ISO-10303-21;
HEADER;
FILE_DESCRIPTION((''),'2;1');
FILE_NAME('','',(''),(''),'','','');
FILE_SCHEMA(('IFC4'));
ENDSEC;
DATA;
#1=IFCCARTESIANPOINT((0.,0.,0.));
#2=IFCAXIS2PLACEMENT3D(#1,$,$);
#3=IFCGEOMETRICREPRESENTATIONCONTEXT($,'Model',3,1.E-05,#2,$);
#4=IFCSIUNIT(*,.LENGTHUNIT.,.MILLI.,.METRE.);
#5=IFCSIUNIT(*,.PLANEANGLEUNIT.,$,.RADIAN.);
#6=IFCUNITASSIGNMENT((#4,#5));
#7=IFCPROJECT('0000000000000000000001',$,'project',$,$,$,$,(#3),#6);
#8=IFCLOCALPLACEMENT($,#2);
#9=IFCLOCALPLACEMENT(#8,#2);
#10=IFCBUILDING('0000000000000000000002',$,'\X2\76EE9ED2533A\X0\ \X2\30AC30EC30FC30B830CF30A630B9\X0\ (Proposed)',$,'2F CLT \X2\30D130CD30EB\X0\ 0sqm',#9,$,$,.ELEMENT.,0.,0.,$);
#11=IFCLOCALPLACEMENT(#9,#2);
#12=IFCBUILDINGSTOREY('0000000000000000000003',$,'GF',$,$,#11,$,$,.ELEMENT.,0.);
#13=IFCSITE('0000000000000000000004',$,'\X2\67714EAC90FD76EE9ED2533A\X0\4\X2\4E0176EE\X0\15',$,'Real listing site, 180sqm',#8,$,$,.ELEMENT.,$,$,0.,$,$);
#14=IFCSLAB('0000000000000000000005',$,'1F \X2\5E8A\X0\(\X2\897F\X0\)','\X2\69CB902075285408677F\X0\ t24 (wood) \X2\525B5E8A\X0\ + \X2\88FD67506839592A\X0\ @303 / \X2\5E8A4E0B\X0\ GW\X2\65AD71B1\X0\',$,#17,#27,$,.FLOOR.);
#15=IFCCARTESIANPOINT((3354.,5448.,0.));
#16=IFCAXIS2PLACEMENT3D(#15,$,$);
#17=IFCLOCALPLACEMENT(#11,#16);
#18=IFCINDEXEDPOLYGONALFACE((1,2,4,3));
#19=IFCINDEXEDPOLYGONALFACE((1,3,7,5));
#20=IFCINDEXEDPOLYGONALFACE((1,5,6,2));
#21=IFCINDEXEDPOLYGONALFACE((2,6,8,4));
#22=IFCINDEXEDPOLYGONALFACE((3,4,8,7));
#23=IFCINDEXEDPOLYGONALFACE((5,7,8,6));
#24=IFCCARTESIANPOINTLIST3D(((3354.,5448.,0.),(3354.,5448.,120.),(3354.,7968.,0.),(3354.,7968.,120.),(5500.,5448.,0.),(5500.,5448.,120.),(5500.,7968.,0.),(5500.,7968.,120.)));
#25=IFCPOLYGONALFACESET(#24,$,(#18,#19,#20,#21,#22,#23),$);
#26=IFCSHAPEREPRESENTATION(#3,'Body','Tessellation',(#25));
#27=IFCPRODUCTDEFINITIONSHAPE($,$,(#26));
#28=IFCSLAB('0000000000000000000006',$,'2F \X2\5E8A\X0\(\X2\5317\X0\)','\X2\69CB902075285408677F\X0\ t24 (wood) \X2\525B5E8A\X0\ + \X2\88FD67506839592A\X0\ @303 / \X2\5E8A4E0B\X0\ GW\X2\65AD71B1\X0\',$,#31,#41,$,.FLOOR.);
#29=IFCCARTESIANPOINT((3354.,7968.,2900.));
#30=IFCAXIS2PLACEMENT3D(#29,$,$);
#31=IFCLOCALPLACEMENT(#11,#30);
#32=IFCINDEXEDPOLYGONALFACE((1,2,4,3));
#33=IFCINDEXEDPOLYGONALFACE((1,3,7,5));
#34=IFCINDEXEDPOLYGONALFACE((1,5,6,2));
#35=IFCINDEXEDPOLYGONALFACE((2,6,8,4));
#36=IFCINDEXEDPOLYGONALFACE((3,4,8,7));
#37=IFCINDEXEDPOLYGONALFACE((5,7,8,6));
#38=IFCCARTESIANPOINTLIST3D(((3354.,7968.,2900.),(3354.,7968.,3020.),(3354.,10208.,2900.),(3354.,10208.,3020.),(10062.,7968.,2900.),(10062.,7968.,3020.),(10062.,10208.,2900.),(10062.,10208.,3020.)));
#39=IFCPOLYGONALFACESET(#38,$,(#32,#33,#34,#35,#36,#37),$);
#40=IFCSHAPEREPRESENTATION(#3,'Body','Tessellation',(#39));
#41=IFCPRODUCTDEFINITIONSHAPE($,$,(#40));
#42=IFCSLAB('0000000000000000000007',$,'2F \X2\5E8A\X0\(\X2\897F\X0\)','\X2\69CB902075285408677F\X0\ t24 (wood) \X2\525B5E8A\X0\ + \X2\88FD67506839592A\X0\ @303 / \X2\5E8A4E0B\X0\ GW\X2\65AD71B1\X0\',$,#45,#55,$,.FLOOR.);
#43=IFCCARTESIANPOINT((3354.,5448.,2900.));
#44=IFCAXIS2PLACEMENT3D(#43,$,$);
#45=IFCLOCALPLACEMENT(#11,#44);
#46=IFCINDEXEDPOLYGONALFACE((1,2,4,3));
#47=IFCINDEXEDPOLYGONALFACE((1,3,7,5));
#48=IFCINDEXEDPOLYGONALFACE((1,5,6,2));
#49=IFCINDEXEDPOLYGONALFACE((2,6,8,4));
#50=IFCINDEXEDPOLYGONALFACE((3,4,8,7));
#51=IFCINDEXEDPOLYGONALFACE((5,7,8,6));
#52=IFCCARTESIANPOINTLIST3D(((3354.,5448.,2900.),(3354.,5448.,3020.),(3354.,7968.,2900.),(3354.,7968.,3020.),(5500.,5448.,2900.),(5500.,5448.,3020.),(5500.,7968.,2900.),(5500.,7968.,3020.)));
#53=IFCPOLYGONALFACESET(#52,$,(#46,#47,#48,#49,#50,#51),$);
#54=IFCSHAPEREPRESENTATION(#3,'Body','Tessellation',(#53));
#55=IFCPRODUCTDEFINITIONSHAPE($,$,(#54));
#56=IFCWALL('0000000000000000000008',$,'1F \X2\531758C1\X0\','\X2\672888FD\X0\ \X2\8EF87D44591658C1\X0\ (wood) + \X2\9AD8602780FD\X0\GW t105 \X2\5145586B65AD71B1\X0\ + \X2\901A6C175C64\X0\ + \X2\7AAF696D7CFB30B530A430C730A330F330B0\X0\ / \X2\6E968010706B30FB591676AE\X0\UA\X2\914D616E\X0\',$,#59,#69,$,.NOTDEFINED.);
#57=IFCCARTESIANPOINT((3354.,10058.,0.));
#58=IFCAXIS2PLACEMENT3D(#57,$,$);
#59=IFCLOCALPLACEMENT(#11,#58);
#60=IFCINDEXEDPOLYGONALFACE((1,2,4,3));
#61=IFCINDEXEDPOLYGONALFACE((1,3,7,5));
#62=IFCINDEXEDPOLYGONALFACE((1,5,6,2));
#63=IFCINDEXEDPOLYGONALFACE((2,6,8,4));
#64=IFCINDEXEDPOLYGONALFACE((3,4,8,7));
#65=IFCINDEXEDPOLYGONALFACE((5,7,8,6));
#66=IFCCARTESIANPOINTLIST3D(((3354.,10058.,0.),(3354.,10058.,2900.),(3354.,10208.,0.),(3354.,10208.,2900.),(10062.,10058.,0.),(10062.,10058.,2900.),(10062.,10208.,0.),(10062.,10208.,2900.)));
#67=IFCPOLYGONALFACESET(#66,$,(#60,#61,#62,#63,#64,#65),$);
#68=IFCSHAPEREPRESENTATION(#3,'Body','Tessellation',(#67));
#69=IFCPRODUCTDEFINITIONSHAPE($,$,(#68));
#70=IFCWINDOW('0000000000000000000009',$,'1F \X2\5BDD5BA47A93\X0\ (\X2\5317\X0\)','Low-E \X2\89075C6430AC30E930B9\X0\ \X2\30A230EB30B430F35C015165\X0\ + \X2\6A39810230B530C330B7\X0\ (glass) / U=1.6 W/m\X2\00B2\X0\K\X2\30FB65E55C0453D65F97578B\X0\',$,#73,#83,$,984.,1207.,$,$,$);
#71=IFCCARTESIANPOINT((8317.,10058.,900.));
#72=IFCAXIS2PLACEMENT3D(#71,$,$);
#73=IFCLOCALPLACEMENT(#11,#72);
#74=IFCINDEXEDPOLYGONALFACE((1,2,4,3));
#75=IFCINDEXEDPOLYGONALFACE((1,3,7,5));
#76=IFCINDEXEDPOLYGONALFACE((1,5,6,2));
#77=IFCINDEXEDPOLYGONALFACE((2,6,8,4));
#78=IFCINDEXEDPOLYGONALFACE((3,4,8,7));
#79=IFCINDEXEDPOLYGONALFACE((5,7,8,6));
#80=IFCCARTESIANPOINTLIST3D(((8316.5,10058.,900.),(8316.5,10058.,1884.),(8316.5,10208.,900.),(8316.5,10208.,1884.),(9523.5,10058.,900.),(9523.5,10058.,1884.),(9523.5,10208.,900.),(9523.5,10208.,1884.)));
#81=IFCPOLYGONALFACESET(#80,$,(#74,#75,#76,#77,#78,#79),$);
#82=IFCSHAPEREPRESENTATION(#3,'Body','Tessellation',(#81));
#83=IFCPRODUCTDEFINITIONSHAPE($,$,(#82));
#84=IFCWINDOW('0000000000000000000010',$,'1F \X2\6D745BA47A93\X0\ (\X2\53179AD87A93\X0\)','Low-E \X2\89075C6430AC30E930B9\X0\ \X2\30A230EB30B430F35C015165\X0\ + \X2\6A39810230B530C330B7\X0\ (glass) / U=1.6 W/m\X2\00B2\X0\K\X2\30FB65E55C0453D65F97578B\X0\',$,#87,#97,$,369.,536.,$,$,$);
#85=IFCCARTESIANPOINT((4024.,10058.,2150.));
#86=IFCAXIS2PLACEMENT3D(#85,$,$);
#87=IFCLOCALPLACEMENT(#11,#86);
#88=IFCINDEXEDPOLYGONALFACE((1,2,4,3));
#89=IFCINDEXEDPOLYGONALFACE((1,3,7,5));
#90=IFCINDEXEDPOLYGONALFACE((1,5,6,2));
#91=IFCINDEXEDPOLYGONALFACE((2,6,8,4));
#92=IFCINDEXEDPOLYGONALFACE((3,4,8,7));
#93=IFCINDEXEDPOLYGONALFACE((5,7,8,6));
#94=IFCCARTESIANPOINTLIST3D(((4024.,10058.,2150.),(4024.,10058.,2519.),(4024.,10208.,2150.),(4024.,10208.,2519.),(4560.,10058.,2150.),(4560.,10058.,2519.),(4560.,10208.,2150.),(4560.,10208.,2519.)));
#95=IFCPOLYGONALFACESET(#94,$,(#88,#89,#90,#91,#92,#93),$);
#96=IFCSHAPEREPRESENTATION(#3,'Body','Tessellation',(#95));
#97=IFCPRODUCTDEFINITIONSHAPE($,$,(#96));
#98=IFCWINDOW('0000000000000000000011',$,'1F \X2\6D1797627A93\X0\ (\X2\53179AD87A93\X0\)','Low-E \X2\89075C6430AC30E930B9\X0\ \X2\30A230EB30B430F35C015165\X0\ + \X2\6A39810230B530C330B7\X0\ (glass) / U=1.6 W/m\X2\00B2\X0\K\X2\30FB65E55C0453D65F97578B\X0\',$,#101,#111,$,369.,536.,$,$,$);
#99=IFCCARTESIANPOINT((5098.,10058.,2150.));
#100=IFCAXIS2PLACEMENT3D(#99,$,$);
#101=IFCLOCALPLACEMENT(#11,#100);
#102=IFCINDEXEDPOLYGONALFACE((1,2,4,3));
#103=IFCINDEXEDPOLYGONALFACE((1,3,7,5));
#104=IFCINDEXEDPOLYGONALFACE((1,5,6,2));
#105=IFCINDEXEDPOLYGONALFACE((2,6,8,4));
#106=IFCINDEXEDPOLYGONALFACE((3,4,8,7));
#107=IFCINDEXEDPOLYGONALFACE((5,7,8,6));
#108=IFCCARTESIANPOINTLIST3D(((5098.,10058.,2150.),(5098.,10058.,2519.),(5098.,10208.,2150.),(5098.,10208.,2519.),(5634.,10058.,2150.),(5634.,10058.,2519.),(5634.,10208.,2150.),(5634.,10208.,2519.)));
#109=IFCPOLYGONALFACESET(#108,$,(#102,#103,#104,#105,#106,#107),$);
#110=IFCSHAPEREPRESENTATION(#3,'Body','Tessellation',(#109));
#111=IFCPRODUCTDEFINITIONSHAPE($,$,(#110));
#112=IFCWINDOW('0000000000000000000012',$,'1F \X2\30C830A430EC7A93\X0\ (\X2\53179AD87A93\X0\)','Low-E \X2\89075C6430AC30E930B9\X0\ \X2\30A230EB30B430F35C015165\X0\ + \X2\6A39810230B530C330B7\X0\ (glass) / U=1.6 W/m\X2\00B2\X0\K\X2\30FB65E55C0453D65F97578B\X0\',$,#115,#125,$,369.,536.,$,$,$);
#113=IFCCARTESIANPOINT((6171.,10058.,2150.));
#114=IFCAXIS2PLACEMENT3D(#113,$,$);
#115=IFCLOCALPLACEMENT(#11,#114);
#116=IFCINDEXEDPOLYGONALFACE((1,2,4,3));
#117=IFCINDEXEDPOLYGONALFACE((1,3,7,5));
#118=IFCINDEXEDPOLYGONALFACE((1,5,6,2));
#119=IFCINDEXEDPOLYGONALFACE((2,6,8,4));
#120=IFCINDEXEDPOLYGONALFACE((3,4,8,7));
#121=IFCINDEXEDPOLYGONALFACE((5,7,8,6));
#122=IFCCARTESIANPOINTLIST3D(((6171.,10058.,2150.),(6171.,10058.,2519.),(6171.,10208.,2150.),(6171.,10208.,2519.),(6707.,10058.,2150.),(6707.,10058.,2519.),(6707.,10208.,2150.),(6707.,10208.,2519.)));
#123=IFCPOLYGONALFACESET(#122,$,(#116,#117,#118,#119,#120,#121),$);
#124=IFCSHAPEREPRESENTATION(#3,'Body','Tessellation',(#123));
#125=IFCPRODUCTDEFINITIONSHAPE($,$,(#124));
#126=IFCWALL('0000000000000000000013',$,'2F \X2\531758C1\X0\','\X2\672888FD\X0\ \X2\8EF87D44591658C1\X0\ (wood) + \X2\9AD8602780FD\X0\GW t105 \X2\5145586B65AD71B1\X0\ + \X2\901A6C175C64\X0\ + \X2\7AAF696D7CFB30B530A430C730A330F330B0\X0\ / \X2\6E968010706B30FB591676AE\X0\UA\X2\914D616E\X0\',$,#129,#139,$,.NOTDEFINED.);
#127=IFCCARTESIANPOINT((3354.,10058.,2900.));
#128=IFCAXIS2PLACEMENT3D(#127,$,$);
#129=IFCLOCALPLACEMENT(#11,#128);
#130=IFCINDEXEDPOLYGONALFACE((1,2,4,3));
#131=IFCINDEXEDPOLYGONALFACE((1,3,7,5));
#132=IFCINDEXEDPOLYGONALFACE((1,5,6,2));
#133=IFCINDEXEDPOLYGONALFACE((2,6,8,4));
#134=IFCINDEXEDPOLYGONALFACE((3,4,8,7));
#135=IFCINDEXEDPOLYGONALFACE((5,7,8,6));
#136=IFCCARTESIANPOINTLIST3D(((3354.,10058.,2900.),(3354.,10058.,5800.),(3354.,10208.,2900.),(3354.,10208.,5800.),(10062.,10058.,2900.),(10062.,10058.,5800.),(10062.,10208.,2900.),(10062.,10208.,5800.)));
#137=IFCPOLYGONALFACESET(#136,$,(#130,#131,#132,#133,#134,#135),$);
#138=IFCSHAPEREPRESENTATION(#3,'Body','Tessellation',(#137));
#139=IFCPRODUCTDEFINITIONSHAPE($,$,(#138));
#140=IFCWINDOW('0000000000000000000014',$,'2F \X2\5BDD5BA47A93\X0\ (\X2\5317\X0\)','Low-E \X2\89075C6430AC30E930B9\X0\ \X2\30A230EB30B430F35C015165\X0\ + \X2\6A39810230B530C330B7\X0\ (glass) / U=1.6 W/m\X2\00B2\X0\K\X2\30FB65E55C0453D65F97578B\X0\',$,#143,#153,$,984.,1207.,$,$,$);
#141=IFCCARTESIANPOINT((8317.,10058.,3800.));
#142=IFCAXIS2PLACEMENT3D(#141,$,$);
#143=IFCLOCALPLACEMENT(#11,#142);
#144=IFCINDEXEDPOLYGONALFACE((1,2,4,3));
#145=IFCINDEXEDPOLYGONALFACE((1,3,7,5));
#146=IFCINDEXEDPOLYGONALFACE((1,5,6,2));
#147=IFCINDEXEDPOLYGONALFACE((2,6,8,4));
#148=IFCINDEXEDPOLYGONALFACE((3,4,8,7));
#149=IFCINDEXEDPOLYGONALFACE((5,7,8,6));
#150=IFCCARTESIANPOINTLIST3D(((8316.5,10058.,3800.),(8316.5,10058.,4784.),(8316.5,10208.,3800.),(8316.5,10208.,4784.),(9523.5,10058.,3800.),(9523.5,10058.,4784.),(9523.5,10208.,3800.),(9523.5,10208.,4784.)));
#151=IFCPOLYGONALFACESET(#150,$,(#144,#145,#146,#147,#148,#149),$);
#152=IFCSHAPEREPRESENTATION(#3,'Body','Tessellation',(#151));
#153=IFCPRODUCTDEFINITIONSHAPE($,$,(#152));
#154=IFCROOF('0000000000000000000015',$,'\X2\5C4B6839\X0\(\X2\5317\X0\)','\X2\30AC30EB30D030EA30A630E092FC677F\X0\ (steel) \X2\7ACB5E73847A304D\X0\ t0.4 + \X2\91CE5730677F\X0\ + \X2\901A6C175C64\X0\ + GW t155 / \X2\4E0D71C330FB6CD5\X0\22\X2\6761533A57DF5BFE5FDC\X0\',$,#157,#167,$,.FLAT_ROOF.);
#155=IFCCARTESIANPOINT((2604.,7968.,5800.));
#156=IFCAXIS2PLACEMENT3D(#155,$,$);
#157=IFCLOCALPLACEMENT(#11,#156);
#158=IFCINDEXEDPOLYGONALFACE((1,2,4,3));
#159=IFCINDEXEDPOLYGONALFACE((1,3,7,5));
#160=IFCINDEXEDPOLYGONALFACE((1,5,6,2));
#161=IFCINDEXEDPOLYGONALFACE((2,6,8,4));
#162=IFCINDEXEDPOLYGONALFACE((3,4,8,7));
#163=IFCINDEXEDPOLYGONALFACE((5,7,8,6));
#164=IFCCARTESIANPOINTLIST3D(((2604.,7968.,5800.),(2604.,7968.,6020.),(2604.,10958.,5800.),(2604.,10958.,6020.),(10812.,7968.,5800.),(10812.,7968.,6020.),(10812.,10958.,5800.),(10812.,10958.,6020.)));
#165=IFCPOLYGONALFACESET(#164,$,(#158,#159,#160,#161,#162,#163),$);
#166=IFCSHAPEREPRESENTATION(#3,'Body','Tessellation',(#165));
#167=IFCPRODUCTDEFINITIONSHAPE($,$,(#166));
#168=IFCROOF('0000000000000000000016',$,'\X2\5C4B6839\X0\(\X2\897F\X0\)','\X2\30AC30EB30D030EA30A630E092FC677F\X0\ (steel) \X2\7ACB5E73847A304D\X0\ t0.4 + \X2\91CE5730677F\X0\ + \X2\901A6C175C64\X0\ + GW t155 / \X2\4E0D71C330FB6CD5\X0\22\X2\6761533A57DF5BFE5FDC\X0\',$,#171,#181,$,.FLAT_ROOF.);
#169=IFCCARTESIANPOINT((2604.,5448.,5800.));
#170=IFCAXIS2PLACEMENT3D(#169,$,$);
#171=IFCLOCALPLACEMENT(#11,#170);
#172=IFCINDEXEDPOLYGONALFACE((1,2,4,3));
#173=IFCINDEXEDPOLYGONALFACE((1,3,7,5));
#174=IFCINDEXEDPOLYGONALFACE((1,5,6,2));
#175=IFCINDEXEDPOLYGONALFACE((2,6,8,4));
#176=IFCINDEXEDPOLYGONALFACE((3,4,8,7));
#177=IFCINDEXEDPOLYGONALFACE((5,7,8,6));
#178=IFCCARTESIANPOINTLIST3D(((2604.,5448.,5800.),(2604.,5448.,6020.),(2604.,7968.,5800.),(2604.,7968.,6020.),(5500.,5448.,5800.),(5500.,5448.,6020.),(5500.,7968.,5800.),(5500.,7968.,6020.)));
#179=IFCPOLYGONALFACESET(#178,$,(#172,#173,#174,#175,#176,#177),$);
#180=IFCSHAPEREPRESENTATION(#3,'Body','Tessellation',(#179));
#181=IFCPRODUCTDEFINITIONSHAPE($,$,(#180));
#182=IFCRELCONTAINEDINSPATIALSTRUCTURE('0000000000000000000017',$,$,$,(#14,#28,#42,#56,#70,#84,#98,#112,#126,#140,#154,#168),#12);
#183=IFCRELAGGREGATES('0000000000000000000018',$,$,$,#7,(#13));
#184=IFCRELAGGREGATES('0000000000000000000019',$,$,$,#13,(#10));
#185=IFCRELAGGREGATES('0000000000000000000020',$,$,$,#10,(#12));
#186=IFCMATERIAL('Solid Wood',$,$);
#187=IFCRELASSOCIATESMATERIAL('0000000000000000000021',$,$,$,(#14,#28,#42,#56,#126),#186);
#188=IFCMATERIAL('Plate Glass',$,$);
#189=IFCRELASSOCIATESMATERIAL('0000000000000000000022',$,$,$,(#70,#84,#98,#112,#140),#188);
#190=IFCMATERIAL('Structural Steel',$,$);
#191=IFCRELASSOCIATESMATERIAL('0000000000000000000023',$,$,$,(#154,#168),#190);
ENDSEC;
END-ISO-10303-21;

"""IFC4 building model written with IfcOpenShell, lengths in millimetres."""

from ifc_helpers import new_model, si_unit, frame, frame_2d, origin, place, context, project, spatial, rectangle, extrude, material, element, fill, save


model = new_model("IFC4")

# Units and contexts
model_context = context("Model", 3, precision=1e-05, world=origin())
ifc_project = project(units=[si_unit("LENGTHUNIT", "METRE", prefix="MILLI"), si_unit("PLANEANGLEUNIT", "RADIAN")], contexts=[model_context])

# Site, building, storey
site_placement = place(None, origin())
site = spatial("IfcSite", under=ifc_project, at=site_placement, Name="東京都目黒区4丁目15", ObjectType="Real listing site, 180sqm", CompositionType="ELEMENT", RefElevation=0.0)
building_placement = place(site_placement, origin())
building = spatial("IfcBuilding", under=site, at=building_placement, Name="目黒区 ガレージハウス (Proposed)", ObjectType="2F CLT パネル 0sqm", CompositionType="ELEMENT", ElevationOfRefHeight=0.0, ElevationOfTerrain=0.0)
storey_placement = place(building_placement, origin())
storey = spatial("IfcBuildingStorey", under=building, at=storey_placement, Name="GF", CompositionType="ELEMENT", Elevation=0.0)

# Slabs
ifc_material_1 = material(Name="Solid Wood")
slab_1_placement = place(storey_placement, frame((3354.0, 5448.0, 0.0)))
element("IfcSlab", 1, at=slab_1_placement, inside=storey, material=ifc_material_1, Name="1F 床(西)", Description="構造用合板 t24 (wood) 剛床 + 製材根太 @303 / 床下 GW断熱", PredefinedType="FLOOR", context=model_context, shape_type="SweptSolid", body=[
    extrude(rectangle(XDim=2146.0, YDim=2520.0, at=frame_2d((1073.0, 1260.0))), frame((3354.0, 5448.0, 0.0)), (0.0, 0.0, 1.0), 120.0),
])
slab_2_placement = place(storey_placement, frame((3354.0, 7968.0, 2900.0)))
element("IfcSlab", 2, at=slab_2_placement, inside=storey, material=ifc_material_1, Name="2F 床(北)", Description="構造用合板 t24 (wood) 剛床 + 製材根太 @303 / 床下 GW断熱", PredefinedType="FLOOR", context=model_context, shape_type="SweptSolid", body=[
    extrude(rectangle(XDim=6708.0, YDim=2240.0, at=frame_2d((3354.0, 1120.0))), frame((3354.0, 7968.0, 2900.0)), (0.0, 0.0, 1.0), 120.0),
])
slab_3_placement = place(storey_placement, frame((3354.0, 5448.0, 2900.0)))
element("IfcSlab", 3, at=slab_3_placement, inside=storey, material=ifc_material_1, Name="2F 床(西)", Description="構造用合板 t24 (wood) 剛床 + 製材根太 @303 / 床下 GW断熱", PredefinedType="FLOOR", context=model_context, shape_type="SweptSolid", body=[
    extrude(rectangle(XDim=2146.0, YDim=2520.0, at=frame_2d((1073.0, 1260.0))), frame((3354.0, 5448.0, 2900.0)), (0.0, 0.0, 1.0), 120.0),
])

# Wall, openings, windows
wall_1_placement = place(storey_placement, frame((3354.0, 10058.0, 0.0)))
wall_1 = element("IfcWall", 4, at=wall_1_placement, inside=storey, material=ifc_material_1, Name="1F 北壁", Description="木製 軸組外壁 (wood) + 高性能GW t105 充填断熱 + 通気層 + 窯業系サイディング / 準耐火・外皮UA配慮", PredefinedType="NOTDEFINED", context=model_context, shape_type="SweptSolid", body=[
    extrude(rectangle(XDim=6708.0, YDim=150.0, at=frame_2d((3354.0, 75.0))), frame((3354.0, 10058.0, 0.0)), (0.0, 0.0, 1.0), 2900.0),
])
opening_1_placement = place(storey_placement, frame((8317.0, 10058.0, 900.0)))
opening_1 = element("IfcOpeningElement", 5, at=opening_1_placement, cuts=wall_1, PredefinedType="NOTDEFINED", context=model_context, shape_type="SweptSolid", body=[
    extrude(rectangle(XDim=1207.0, YDim=150.0, at=frame_2d((603.0, 75.0))), frame((8317.0, 10058.0, 900.0)), (0.0, 0.0, 1.0), 984.0),
])
opening_2_placement = place(storey_placement, frame((4024.0, 10058.0, 2150.0)))
opening_2 = element("IfcOpeningElement", 6, at=opening_2_placement, cuts=wall_1, PredefinedType="NOTDEFINED", context=model_context, shape_type="SweptSolid", body=[
    extrude(rectangle(XDim=536.0, YDim=150.0, at=frame_2d((268.0, 75.0))), frame((4024.0, 10058.0, 2150.0)), (0.0, 0.0, 1.0), 369.0),
])
opening_3_placement = place(storey_placement, frame((5098.0, 10058.0, 2150.0)))
opening_3 = element("IfcOpeningElement", 7, at=opening_3_placement, cuts=wall_1, PredefinedType="NOTDEFINED", context=model_context, shape_type="SweptSolid", body=[
    extrude(rectangle(XDim=536.0, YDim=150.0, at=frame_2d((268.0, 75.0))), frame((5098.0, 10058.0, 2150.0)), (0.0, 0.0, 1.0), 369.0),
])
opening_4_placement = place(storey_placement, frame((6171.0, 10058.0, 2150.0)))
opening_4 = element("IfcOpeningElement", 8, at=opening_4_placement, cuts=wall_1, PredefinedType="NOTDEFINED", context=model_context, shape_type="SweptSolid", body=[
    extrude(rectangle(XDim=536.0, YDim=150.0, at=frame_2d((268.0, 75.0))), frame((6171.0, 10058.0, 2150.0)), (0.0, 0.0, 1.0), 369.0),
])
ifc_material_2 = material(Name="Plate Glass")
window_1_placement = place(storey_placement, frame((8317.0, 10058.0, 900.0)))
window_1 = element("IfcWindow", 9, at=window_1_placement, inside=storey, material=ifc_material_2, Name="1F 寝室窓 (北)", Description="Low-E 複層ガラス アルゴン封入 + 樹脂サッシ (glass) / U=1.6 W/m²K・日射取得型", OverallHeight=984.0, OverallWidth=1207.0, context=model_context, shape_type="SweptSolid", body=[
    extrude(rectangle(XDim=1207.0, YDim=150.0, at=frame_2d((603.0, 75.0))), frame((8317.0, 10058.0, 900.0)), (0.0, 0.0, 1.0), 984.0),
])
fill(opening_1, window_1)
window_2_placement = place(storey_placement, frame((4024.0, 10058.0, 2150.0)))
window_2 = element("IfcWindow", 10, at=window_2_placement, inside=storey, material=ifc_material_2, Name="1F 浴室窓 (北高窓)", Description="Low-E 複層ガラス アルゴン封入 + 樹脂サッシ (glass) / U=1.6 W/m²K・日射取得型", OverallHeight=369.0, OverallWidth=536.0, context=model_context, shape_type="SweptSolid", body=[
    extrude(rectangle(XDim=536.0, YDim=150.0, at=frame_2d((268.0, 75.0))), frame((4024.0, 10058.0, 2150.0)), (0.0, 0.0, 1.0), 369.0),
])
fill(opening_2, window_2)
window_3_placement = place(storey_placement, frame((5098.0, 10058.0, 2150.0)))
window_3 = element("IfcWindow", 11, at=window_3_placement, inside=storey, material=ifc_material_2, Name="1F 洗面窓 (北高窓)", Description="Low-E 複層ガラス アルゴン封入 + 樹脂サッシ (glass) / U=1.6 W/m²K・日射取得型", OverallHeight=369.0, OverallWidth=536.0, context=model_context, shape_type="SweptSolid", body=[
    extrude(rectangle(XDim=536.0, YDim=150.0, at=frame_2d((268.0, 75.0))), frame((5098.0, 10058.0, 2150.0)), (0.0, 0.0, 1.0), 369.0),
])
fill(opening_3, window_3)
window_4_placement = place(storey_placement, frame((6171.0, 10058.0, 2150.0)))
window_4 = element("IfcWindow", 12, at=window_4_placement, inside=storey, material=ifc_material_2, Name="1F トイレ窓 (北高窓)", Description="Low-E 複層ガラス アルゴン封入 + 樹脂サッシ (glass) / U=1.6 W/m²K・日射取得型", OverallHeight=369.0, OverallWidth=536.0, context=model_context, shape_type="SweptSolid", body=[
    extrude(rectangle(XDim=536.0, YDim=150.0, at=frame_2d((268.0, 75.0))), frame((6171.0, 10058.0, 2150.0)), (0.0, 0.0, 1.0), 369.0),
])
fill(opening_4, window_4)

# Wall, opening, window
wall_2_placement = place(storey_placement, frame((3354.0, 10058.0, 2900.0)))
wall_2 = element("IfcWall", 13, at=wall_2_placement, inside=storey, material=ifc_material_1, Name="2F 北壁", Description="木製 軸組外壁 (wood) + 高性能GW t105 充填断熱 + 通気層 + 窯業系サイディング / 準耐火・外皮UA配慮", PredefinedType="NOTDEFINED", context=model_context, shape_type="SweptSolid", body=[
    extrude(rectangle(XDim=6708.0, YDim=150.0, at=frame_2d((3354.0, 75.0))), frame((3354.0, 10058.0, 2900.0)), (0.0, 0.0, 1.0), 2900.0),
])
opening_5_placement = place(storey_placement, frame((8317.0, 10058.0, 3800.0)))
opening_5 = element("IfcOpeningElement", 14, at=opening_5_placement, cuts=wall_2, PredefinedType="NOTDEFINED", context=model_context, shape_type="SweptSolid", body=[
    extrude(rectangle(XDim=1207.0, YDim=150.0, at=frame_2d((603.0, 75.0))), frame((8317.0, 10058.0, 3800.0)), (0.0, 0.0, 1.0), 984.0),
])
window_5_placement = place(storey_placement, frame((8317.0, 10058.0, 3800.0)))
window_5 = element("IfcWindow", 15, at=window_5_placement, inside=storey, material=ifc_material_2, Name="2F 寝室窓 (北)", Description="Low-E 複層ガラス アルゴン封入 + 樹脂サッシ (glass) / U=1.6 W/m²K・日射取得型", OverallHeight=984.0, OverallWidth=1207.0, context=model_context, shape_type="SweptSolid", body=[
    extrude(rectangle(XDim=1207.0, YDim=150.0, at=frame_2d((603.0, 75.0))), frame((8317.0, 10058.0, 3800.0)), (0.0, 0.0, 1.0), 984.0),
])
fill(opening_5, window_5)

# Roofs
ifc_material_3 = material(Name="Structural Steel")
for number, where, name in (
    (16, (2604.0, 7968.0, 5800.0), "屋根(北)"),
):
    element("IfcRoof", number, at=place(storey_placement, frame(where)), inside=storey, material=ifc_material_3, Name=name, Description="ガルバリウム鋼板 (steel) 立平葺き t0.4 + 野地板 + 通気層 + GW t155 / 不燃・法22条区域対応", PredefinedType="FLAT_ROOF", context=model_context, shape_type="SweptSolid", body=[
        extrude(rectangle(XDim=8208.0, YDim=2990.0, at=frame_2d((4104.0, 1495.0))), frame((2604.0, 7968.0, 5800.0)), (0.0, 0.0, 1.0), 220.0),
    ])
roof_placement = place(storey_placement, frame((2604.0, 5448.0, 5800.0)))
element("IfcRoof", 17, at=roof_placement, inside=storey, material=ifc_material_3, Name="屋根(西)", Description="ガルバリウム鋼板 (steel) 立平葺き t0.4 + 野地板 + 通気層 + GW t155 / 不燃・法22条区域対応", PredefinedType="FLAT_ROOF", context=model_context, shape_type="SweptSolid", body=[
    extrude(rectangle(XDim=2896.0, YDim=2520.0, at=frame_2d((1448.0, 1260.0))), frame((2604.0, 5448.0, 5800.0)), (0.0, 0.0, 1.0), 220.0),
])

save(model, "model.ifc")
